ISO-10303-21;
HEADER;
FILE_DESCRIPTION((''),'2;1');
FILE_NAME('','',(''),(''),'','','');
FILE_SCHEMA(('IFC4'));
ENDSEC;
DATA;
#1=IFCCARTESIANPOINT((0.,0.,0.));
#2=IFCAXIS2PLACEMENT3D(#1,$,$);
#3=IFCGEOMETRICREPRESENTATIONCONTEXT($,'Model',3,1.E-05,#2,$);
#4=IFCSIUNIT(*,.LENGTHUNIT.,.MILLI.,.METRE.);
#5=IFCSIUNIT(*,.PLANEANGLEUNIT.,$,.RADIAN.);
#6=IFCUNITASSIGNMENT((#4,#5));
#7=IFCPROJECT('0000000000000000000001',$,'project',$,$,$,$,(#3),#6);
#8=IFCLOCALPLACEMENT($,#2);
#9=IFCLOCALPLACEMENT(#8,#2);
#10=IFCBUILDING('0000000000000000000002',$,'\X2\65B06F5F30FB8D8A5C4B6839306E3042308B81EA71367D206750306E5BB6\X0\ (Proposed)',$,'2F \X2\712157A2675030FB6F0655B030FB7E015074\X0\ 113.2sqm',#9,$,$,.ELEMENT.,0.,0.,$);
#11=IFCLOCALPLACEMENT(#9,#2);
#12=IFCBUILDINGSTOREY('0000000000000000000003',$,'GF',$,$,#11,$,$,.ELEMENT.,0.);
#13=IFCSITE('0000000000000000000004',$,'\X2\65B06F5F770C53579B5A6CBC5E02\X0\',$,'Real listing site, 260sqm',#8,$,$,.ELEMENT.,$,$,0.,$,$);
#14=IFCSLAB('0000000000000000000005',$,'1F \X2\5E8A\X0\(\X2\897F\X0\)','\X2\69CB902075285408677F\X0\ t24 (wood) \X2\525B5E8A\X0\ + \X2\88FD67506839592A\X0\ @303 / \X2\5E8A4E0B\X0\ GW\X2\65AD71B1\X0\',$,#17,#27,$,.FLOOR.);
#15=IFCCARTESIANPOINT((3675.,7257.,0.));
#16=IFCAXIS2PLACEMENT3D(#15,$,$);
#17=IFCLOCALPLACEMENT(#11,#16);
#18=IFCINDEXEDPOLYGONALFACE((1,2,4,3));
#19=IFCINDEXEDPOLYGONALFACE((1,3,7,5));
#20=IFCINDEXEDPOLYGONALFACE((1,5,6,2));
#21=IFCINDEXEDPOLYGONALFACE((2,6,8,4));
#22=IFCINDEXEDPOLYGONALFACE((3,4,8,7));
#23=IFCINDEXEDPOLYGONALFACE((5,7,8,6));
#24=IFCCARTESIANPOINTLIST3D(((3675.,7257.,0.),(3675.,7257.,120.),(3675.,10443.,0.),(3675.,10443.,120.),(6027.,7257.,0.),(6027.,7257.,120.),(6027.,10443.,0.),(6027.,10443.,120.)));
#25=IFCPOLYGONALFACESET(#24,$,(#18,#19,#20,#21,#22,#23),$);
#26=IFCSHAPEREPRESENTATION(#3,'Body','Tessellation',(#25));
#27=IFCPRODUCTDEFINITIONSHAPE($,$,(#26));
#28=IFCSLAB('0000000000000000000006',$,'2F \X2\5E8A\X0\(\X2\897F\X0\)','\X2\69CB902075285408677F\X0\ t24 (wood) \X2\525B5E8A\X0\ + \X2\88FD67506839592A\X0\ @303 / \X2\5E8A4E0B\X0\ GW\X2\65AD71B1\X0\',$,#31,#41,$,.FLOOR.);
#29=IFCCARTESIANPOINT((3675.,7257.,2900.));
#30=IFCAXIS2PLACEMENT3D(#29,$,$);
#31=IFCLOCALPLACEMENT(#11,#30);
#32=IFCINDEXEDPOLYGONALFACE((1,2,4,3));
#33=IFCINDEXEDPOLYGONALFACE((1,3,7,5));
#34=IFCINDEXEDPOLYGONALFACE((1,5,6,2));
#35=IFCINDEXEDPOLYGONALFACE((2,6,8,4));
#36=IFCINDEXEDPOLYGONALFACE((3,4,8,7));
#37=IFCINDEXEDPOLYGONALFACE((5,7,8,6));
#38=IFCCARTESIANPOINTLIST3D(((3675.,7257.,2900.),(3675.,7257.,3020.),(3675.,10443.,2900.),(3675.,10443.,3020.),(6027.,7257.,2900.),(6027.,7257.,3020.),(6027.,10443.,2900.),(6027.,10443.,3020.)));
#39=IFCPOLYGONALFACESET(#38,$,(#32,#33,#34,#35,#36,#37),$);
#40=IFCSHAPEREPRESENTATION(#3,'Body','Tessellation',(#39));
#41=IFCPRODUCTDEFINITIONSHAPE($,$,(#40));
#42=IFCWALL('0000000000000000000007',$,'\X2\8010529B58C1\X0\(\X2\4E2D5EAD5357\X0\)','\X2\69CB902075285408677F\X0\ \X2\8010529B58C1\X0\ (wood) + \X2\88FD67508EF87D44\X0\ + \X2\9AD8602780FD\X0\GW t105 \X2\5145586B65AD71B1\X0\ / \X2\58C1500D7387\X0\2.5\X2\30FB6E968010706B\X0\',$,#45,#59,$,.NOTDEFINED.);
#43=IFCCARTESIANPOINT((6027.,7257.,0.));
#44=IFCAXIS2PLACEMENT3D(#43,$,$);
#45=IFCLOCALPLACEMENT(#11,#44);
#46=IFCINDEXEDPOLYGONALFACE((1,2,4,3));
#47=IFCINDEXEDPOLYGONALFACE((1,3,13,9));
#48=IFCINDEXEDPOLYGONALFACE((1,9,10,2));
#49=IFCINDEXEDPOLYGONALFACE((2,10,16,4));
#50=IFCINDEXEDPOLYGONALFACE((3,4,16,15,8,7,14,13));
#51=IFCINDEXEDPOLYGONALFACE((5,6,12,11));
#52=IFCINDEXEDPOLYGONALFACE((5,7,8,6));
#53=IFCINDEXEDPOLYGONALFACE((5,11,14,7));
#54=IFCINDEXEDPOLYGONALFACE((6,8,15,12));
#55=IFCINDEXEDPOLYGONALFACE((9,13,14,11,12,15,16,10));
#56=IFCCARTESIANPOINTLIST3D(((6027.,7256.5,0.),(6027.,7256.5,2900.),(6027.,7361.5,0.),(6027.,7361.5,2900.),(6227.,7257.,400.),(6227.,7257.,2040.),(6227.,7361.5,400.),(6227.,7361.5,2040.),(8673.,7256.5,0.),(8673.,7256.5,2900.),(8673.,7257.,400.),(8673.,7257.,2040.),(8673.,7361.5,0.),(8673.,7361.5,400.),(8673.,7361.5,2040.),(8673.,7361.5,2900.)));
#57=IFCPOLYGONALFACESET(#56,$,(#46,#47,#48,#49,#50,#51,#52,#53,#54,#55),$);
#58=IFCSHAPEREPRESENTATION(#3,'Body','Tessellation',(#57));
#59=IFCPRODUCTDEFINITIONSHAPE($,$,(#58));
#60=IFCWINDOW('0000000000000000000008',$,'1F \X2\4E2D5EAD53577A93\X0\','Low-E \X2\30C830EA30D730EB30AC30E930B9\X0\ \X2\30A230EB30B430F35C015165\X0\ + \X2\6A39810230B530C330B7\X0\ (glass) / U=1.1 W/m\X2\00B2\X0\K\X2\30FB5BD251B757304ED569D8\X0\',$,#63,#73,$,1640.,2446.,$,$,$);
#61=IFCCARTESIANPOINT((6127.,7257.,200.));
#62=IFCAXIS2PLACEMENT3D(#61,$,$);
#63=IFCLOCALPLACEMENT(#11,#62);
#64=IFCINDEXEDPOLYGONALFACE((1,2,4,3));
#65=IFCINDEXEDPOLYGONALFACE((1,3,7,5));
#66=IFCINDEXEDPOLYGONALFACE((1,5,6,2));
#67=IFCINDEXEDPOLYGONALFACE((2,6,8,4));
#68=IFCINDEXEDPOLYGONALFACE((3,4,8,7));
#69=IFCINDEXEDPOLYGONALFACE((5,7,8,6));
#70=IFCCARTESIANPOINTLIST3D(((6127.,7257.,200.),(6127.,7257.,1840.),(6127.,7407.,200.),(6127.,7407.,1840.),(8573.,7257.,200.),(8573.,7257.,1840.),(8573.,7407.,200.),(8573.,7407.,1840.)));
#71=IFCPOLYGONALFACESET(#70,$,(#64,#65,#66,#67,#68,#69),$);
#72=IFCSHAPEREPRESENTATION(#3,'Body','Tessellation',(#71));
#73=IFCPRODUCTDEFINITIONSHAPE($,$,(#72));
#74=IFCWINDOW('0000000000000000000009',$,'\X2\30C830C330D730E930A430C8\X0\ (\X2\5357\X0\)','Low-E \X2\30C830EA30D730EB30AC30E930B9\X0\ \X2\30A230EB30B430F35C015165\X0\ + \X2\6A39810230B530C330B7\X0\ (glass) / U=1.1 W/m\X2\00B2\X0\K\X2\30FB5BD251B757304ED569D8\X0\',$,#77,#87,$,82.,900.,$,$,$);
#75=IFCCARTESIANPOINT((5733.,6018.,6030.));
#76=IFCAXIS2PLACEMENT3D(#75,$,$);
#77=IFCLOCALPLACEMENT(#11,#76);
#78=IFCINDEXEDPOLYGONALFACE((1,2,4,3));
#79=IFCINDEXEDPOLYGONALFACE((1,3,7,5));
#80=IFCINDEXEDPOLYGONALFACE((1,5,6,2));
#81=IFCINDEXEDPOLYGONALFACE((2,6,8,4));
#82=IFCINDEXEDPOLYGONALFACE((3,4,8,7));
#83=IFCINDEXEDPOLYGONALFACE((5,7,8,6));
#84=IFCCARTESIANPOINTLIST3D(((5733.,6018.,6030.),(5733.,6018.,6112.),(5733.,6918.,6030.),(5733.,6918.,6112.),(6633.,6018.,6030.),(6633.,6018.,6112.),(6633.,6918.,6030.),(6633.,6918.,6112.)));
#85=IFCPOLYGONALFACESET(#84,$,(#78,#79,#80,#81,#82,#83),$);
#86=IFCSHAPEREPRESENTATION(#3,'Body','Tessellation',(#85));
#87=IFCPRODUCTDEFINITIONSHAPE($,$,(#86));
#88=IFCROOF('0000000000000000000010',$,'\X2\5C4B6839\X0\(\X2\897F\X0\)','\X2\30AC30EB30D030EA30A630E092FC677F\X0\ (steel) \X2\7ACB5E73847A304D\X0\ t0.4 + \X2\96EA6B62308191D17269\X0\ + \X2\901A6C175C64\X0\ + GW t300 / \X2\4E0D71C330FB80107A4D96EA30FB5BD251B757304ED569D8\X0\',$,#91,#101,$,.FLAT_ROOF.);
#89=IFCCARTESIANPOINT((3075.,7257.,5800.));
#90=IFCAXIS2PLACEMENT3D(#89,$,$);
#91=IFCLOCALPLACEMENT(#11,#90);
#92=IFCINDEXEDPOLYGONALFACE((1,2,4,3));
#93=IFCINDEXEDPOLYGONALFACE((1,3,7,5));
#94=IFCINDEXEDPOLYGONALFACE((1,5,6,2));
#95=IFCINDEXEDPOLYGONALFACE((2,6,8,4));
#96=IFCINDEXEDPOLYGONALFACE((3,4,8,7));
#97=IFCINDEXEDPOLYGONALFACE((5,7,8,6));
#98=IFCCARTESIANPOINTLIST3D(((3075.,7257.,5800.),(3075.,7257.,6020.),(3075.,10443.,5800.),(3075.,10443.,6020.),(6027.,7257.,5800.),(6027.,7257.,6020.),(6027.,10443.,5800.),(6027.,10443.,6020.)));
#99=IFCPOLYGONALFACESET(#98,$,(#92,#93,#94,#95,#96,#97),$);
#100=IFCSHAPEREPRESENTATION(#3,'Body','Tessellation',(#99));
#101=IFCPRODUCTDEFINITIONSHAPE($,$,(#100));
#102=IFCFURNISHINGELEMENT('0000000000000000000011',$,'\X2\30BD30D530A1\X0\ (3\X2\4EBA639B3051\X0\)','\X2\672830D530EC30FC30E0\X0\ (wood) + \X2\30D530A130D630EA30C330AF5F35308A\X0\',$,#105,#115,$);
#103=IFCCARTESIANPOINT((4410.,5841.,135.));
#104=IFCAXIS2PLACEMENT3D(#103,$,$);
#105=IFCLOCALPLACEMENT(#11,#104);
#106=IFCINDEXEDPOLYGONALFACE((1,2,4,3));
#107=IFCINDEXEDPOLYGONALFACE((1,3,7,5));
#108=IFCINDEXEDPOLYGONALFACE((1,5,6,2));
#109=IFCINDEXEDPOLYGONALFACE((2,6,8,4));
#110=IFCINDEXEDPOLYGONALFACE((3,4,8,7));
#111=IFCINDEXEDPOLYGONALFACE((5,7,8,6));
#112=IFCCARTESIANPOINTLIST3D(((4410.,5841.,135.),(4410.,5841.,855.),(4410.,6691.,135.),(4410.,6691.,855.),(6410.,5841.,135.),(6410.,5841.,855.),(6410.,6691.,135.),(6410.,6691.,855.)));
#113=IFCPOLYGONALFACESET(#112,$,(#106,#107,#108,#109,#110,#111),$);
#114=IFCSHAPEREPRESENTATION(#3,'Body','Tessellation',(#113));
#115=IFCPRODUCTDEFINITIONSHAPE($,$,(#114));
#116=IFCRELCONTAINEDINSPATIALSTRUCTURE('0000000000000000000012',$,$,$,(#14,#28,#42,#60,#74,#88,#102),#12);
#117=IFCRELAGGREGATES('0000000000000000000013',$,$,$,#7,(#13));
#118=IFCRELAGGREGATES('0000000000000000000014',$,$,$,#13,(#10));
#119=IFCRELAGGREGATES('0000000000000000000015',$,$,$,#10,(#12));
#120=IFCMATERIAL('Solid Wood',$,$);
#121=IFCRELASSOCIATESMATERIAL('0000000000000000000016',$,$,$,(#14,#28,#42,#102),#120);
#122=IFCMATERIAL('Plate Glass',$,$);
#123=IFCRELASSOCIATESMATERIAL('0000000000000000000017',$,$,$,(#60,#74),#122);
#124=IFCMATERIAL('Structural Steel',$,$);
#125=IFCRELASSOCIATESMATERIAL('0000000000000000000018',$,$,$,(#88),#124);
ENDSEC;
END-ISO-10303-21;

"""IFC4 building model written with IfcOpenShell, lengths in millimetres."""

from ifc_helpers import new_model, si_unit, frame, frame_2d, origin, place, context, project, spatial, rectangle, extrude, material, element, fill, save


model = new_model("IFC4")

# Units and contexts
model_context = context("Model", 3, precision=1e-05, world=origin())
ifc_project = project(units=[si_unit("LENGTHUNIT", "METRE", prefix="MILLI"), si_unit("PLANEANGLEUNIT", "RADIAN")], contexts=[model_context])

# Site, building, storey
site_placement = place(None, origin())
site = spatial("IfcSite", under=ifc_project, at=site_placement, Name="新潟県南魚沼市", ObjectType="Real listing site, 260sqm", CompositionType="ELEMENT", RefElevation=0.0)
building_placement = place(site_placement, origin())
building = spatial("IfcBuilding", under=site, at=building_placement, Name="新潟・越屋根のある自然素材の家 (Proposed)", ObjectType="2F 無垢材・漆喰・縁側 113.2sqm", CompositionType="ELEMENT", ElevationOfRefHeight=0.0, ElevationOfTerrain=0.0)
storey_placement = place(building_placement, origin())
storey = spatial("IfcBuildingStorey", under=building, at=storey_placement, Name="GF", CompositionType="ELEMENT", Elevation=0.0)

# Shared definitions
ifc_material_1 = material(Name="Solid Wood")

# Slabs
slab_1_placement = place(storey_placement, frame((3675.0, 7257.0, 0.0)))
element("IfcSlab", 1, at=slab_1_placement, inside=storey, material=ifc_material_1, Name="1F 床(西)", Description="構造用合板 t24 (wood) 剛床 + 製材根太 @303 / 床下 GW断熱", PredefinedType="FLOOR", context=model_context, shape_type="SweptSolid", body=[
    extrude(rectangle(XDim=2352.0, YDim=3186.0, at=frame_2d((1176.0, 1593.0))), frame((3675.0, 7257.0, 0.0)), (0.0, 0.0, 1.0), 120.0),
])
slab_2_placement = place(storey_placement, frame((3675.0, 7257.0, 2900.0)))
element("IfcSlab", 2, at=slab_2_placement, inside=storey, material=ifc_material_1, Name="2F 床(西)", Description="構造用合板 t24 (wood) 剛床 + 製材根太 @303 / 床下 GW断熱", PredefinedType="FLOOR", context=model_context, shape_type="SweptSolid", body=[
    extrude(rectangle(XDim=2352.0, YDim=3186.0, at=frame_2d((1176.0, 1593.0))), frame((3675.0, 7257.0, 2900.0)), (0.0, 0.0, 1.0), 120.0),
])

# Wall, opening, window
wall_placement = place(storey_placement, frame((6027.0, 7257.0, 0.0)))
wall = element("IfcWall", 3, at=wall_placement, inside=storey, material=ifc_material_1, Name="耐力壁(中庭南)", Description="構造用合板 耐力壁 (wood) + 製材軸組 + 高性能GW t105 充填断熱 / 壁倍率2.5・準耐火", PredefinedType="NOTDEFINED", context=model_context, shape_type="SweptSolid", body=[
    extrude(rectangle(XDim=2646.0, YDim=105.0, at=frame_2d((1323.0, 52.0))), frame((6027.0, 7257.0, 0.0)), (0.0, 0.0, 1.0), 2900.0),
])
opening_placement = place(storey_placement, frame((6127.0, 7257.0, 200.0)))
opening = element("IfcOpeningElement", 4, at=opening_placement, cuts=wall, PredefinedType="NOTDEFINED", context=model_context, shape_type="SweptSolid", body=[
    extrude(rectangle(XDim=2446.0, YDim=150.0, at=frame_2d((1223.0, 75.0))), frame((6127.0, 7257.0, 200.0)), (0.0, 0.0, 1.0), 1640.0),
])
ifc_material_2 = material(Name="Plate Glass")
window_1_placement = place(storey_placement, frame((6127.0, 7257.0, 200.0)))
window_1 = element("IfcWindow", 5, at=window_1_placement, inside=storey, material=ifc_material_2, Name="1F 中庭南窓", Description="Low-E トリプルガラス アルゴン封入 + 樹脂サッシ (glass) / U=1.1 W/m²K・寒冷地仕様", OverallHeight=1640.0, OverallWidth=2446.0, context=model_context, shape_type="SweptSolid", body=[
    extrude(rectangle(XDim=2446.0, YDim=150.0, at=frame_2d((1223.0, 75.0))), frame((6127.0, 7257.0, 200.0)), (0.0, 0.0, 1.0), 1640.0),
])
fill(opening, window_1)

# Window
window_2_placement = place(storey_placement, frame((5733.0, 6018.0, 6030.0)))
element("IfcWindow", 6, at=window_2_placement, inside=storey, material=ifc_material_2, Name="トップライト (南)", Description="Low-E トリプルガラス アルゴン封入 + 樹脂サッシ (glass) / U=1.1 W/m²K・寒冷地仕様", OverallHeight=82.0, OverallWidth=900.0, context=model_context, shape_type="SweptSolid", body=[
    extrude(rectangle(XDim=900.0, YDim=900.0, at=frame_2d((450.0, 450.0))), frame((5733.0, 6018.0, 6030.0)), (0.0, 0.0, 1.0), 82.0),
])

# Roof
ifc_material_3 = material(Name="Structural Steel")
for number, where, name in (
    (7, (3075.0, 7257.0, 5800.0), "屋根(西)"),
):
    element("IfcRoof", number, at=place(storey_placement, frame(where)), inside=storey, material=ifc_material_3, Name=name, Description="ガルバリウム鋼板 (steel) 立平葺き t0.4 + 雪止め金物 + 通気層 + GW t300 / 不燃・耐積雪・寒冷地仕様", PredefinedType="FLAT_ROOF", context=model_context, shape_type="SweptSolid", body=[
        extrude(rectangle(XDim=2952.0, YDim=3186.0, at=frame_2d((1476.0, 1593.0))), frame((3075.0, 7257.0, 5800.0)), (0.0, 0.0, 1.0), 220.0),
    ])

# Furnishing element
furnishing_placement = place(storey_placement, frame((4410.0, 5841.0, 135.0)))
element("IfcFurnishingElement", 8, at=furnishing_placement, inside=storey, material=ifc_material_1, Name="ソファ (3人掛け)", Description="木フレーム (wood) + ファブリック張り", context=model_context, shape_type="SweptSolid", body=[
    extrude(rectangle(XDim=2000.0, YDim=850.0, at=frame_2d((1000.0, 425.0))), frame((4410.0, 5841.0, 135.0)), (0.0, 0.0, 1.0), 720.0),
])

save(model, "model.ifc")
